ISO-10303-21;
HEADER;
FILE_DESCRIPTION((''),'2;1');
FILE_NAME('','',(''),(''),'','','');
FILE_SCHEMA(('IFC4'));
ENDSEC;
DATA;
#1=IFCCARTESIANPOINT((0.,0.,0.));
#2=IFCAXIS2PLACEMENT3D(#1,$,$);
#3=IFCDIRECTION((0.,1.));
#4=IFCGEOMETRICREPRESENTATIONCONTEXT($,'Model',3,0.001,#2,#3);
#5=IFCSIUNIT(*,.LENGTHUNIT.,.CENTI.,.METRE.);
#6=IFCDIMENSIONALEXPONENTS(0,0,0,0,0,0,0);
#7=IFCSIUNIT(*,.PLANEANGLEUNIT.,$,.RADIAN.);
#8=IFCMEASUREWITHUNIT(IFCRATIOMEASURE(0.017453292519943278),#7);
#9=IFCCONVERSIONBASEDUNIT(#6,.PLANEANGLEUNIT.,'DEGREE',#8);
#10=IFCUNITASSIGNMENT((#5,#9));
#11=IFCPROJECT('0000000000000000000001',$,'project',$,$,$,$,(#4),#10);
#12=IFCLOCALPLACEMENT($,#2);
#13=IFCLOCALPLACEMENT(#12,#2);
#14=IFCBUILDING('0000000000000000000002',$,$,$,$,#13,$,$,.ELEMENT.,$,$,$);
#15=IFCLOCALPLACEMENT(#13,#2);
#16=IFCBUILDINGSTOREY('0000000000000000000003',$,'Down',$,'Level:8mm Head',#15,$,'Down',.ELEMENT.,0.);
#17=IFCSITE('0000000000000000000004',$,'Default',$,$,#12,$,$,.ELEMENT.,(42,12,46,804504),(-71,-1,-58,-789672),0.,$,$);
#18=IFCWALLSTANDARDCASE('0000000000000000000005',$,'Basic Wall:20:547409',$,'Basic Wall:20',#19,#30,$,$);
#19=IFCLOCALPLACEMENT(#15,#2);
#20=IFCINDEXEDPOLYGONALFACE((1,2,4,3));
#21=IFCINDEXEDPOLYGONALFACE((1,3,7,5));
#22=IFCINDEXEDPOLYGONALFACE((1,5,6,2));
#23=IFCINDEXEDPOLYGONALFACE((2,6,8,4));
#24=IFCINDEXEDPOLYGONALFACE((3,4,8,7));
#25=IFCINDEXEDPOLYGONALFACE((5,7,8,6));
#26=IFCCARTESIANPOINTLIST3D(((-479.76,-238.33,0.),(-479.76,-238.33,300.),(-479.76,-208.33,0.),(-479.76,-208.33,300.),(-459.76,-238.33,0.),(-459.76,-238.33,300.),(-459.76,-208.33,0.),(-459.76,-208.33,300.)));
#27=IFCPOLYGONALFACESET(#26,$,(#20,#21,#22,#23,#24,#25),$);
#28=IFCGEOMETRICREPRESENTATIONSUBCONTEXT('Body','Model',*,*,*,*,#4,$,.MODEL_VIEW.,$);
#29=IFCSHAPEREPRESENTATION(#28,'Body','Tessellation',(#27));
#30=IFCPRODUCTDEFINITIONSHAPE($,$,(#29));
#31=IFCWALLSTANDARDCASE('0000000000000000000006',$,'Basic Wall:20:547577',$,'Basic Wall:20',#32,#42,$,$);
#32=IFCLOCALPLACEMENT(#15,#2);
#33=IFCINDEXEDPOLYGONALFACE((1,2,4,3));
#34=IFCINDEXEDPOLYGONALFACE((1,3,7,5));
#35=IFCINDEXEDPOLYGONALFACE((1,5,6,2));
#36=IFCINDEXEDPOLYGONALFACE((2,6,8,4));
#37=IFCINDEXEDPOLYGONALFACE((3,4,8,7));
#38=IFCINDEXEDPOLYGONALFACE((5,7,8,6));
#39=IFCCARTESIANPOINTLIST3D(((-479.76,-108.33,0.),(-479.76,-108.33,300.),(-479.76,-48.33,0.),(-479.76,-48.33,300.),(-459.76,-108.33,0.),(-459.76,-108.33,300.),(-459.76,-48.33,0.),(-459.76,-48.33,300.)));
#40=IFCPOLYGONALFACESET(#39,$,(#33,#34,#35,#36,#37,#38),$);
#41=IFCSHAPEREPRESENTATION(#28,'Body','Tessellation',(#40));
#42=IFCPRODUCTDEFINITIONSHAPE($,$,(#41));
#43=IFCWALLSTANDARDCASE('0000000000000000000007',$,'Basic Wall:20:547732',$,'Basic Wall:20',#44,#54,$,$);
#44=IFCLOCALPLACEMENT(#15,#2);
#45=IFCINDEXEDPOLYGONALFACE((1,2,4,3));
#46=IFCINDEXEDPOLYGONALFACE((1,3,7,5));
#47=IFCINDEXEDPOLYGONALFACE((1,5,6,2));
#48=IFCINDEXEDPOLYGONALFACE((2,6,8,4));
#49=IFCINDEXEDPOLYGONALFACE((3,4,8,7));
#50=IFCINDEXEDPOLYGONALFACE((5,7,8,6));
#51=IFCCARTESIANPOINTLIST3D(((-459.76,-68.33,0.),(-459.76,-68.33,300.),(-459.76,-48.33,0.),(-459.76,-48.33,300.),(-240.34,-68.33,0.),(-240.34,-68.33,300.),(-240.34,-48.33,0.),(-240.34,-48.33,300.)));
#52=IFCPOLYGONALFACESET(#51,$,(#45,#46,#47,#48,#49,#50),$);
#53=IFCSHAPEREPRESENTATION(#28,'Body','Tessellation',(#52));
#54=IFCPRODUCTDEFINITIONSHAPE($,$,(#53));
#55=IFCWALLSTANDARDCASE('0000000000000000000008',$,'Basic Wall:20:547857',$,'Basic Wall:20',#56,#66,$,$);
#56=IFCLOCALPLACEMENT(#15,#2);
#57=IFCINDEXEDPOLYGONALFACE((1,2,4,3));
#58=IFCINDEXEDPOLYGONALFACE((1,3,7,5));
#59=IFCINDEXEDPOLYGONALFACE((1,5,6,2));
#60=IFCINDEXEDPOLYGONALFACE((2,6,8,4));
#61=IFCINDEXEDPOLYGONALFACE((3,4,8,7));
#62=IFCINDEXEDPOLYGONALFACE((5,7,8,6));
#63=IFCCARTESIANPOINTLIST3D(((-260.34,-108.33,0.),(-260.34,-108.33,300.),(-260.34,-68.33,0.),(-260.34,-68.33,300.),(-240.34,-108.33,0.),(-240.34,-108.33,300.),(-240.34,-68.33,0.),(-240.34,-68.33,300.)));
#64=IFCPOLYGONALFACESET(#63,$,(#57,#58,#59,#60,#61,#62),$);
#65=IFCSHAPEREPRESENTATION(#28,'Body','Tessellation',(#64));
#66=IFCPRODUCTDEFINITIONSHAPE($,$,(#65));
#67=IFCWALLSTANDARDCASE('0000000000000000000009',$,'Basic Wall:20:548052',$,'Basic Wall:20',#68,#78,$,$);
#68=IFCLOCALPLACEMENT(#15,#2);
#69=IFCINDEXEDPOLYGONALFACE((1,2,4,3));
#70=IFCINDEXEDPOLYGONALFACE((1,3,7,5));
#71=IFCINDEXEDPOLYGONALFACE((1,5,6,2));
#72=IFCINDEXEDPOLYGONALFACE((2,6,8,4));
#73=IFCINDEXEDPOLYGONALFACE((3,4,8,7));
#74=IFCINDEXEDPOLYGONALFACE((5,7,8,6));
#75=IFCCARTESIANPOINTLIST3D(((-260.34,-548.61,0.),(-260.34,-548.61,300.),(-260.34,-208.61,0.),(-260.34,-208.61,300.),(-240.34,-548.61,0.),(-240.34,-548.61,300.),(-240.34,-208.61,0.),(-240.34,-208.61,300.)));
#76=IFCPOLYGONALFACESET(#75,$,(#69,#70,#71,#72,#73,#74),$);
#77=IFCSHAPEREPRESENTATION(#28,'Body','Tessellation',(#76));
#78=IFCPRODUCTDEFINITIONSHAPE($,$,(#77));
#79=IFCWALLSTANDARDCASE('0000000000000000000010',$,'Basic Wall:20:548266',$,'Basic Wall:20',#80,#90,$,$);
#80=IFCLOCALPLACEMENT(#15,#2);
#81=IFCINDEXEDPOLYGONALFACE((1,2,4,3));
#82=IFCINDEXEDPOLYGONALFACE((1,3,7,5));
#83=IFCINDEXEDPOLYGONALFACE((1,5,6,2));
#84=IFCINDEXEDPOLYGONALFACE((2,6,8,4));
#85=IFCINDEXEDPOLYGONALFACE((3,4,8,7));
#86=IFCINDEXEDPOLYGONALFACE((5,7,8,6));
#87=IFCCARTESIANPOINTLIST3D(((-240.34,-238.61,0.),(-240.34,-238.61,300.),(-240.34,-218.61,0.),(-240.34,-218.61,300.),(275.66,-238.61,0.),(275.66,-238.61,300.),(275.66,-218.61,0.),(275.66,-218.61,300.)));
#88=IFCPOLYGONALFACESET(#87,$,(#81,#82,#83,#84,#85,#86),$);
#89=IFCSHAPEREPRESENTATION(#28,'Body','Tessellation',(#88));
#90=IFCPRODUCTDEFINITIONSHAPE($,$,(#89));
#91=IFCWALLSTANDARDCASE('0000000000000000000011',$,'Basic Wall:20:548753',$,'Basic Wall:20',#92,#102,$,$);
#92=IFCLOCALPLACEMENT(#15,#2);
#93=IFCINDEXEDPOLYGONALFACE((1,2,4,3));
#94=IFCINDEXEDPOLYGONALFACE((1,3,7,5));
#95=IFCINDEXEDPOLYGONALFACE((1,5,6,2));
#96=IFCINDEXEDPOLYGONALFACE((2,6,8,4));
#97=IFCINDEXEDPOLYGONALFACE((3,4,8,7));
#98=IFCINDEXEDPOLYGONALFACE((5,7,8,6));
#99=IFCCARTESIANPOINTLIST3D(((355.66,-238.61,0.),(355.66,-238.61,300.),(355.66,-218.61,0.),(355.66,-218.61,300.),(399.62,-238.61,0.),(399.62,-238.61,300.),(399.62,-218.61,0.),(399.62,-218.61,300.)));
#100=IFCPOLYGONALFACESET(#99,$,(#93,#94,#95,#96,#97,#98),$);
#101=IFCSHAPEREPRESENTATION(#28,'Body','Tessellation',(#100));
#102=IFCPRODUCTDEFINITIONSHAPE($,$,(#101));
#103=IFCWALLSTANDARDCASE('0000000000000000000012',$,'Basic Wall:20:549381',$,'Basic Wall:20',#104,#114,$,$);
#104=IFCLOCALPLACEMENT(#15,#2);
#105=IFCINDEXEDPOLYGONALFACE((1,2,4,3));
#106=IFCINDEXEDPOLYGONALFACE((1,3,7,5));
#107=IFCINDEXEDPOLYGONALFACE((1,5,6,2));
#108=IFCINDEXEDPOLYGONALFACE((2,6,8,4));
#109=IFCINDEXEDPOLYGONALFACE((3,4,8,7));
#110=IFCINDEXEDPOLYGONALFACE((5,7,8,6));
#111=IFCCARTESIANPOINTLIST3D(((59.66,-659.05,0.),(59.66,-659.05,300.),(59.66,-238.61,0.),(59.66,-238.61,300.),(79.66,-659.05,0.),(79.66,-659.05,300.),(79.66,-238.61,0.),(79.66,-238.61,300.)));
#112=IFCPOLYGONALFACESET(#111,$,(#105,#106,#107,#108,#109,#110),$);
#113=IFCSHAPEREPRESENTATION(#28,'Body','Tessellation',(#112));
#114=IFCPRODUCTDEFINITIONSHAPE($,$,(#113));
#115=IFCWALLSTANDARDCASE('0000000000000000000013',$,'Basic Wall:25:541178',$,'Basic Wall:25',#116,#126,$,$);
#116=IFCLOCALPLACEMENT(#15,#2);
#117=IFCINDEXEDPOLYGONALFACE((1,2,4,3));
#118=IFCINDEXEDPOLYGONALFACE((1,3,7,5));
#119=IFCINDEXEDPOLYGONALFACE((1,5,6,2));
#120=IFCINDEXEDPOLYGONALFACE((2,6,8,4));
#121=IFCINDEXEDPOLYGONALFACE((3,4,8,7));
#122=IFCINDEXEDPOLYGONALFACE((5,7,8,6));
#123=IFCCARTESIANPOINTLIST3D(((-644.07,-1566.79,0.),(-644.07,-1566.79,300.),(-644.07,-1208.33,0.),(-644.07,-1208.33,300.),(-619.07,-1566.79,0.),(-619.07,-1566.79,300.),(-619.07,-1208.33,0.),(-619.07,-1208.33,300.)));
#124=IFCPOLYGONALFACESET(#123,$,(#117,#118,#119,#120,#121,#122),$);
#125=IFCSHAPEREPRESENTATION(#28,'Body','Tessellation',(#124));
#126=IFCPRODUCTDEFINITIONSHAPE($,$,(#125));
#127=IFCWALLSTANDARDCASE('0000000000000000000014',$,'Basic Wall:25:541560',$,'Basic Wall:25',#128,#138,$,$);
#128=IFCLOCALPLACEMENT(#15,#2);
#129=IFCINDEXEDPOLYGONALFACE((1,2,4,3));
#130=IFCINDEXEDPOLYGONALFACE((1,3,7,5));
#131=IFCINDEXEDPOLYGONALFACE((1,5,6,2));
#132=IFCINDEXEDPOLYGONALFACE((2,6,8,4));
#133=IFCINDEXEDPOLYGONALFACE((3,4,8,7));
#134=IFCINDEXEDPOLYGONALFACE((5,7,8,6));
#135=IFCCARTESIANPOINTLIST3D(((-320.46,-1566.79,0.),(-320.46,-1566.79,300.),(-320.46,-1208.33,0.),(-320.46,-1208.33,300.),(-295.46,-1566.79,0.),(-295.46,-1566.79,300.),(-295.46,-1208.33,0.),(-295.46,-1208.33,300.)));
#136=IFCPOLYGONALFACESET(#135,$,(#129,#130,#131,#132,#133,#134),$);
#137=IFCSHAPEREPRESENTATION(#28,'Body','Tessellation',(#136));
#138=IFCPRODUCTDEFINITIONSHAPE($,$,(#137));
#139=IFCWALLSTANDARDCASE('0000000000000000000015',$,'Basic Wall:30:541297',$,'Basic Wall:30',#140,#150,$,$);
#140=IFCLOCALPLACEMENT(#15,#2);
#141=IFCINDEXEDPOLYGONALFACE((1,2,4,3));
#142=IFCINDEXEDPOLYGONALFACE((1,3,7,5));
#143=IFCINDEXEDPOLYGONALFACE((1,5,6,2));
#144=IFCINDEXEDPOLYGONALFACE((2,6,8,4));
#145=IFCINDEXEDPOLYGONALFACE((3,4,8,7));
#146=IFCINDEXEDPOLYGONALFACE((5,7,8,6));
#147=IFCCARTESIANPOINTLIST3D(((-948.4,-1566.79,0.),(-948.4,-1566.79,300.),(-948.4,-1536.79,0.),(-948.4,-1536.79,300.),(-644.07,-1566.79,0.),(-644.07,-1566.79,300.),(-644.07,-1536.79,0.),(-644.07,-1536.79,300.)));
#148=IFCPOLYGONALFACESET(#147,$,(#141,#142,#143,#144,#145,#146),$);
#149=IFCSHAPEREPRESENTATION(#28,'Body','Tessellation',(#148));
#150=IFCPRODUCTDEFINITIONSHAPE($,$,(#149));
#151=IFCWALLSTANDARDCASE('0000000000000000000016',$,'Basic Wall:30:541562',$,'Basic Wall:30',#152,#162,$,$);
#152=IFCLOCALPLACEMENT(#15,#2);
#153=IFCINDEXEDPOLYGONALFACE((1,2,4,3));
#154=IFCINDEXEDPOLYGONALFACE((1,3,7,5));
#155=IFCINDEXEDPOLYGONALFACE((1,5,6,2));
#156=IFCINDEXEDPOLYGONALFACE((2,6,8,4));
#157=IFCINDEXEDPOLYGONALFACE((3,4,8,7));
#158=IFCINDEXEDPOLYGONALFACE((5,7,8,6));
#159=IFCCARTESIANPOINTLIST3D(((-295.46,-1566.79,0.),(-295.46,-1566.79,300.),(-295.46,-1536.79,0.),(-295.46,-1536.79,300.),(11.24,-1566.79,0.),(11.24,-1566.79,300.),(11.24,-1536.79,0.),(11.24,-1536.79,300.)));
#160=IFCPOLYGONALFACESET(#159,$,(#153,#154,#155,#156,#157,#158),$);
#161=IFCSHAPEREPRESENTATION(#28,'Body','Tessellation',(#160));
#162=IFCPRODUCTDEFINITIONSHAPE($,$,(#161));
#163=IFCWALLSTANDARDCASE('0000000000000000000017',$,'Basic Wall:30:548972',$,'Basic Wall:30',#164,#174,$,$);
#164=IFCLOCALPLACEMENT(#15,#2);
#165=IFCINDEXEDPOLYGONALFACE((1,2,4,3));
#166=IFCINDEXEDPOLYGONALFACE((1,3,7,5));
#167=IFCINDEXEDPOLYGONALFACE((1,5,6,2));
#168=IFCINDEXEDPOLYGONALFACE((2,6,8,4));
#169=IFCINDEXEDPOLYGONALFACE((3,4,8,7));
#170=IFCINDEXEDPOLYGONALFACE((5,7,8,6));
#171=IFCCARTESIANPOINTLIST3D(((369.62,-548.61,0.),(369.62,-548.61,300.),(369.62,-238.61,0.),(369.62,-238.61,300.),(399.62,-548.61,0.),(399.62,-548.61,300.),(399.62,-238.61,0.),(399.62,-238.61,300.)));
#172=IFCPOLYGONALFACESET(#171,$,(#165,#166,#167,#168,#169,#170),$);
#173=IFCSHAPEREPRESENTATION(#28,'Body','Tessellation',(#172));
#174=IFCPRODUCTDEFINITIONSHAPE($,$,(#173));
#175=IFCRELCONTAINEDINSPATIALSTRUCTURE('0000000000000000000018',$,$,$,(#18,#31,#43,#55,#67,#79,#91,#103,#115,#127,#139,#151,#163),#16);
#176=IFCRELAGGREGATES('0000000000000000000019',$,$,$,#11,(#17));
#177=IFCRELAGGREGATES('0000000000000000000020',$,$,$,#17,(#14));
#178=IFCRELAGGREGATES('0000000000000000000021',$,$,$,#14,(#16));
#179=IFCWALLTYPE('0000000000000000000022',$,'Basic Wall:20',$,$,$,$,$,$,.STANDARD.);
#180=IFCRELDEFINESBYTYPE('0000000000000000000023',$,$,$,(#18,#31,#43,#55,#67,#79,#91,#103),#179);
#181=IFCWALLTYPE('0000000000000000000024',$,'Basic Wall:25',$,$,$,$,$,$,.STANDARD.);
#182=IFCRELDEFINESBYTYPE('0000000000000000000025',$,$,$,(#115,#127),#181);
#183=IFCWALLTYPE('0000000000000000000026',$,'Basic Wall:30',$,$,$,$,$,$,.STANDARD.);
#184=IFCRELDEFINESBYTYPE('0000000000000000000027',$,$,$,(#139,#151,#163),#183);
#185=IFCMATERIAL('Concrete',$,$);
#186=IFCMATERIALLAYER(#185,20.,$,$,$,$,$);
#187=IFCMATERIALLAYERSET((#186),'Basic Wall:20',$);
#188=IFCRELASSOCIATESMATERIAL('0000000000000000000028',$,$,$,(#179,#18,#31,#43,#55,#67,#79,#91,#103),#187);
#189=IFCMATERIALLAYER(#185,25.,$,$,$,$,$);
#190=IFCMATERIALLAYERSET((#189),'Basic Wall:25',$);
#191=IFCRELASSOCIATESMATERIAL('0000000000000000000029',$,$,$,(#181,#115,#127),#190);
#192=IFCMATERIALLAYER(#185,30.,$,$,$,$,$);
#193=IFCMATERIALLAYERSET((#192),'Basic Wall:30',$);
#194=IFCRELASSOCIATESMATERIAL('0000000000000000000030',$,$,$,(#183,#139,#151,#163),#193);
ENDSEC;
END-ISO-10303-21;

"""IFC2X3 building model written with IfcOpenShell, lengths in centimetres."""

from ifc_helpers import new_model, entity, si_unit, converted_unit, direction, frame, frame_2d, origin, place, context, subcontext, project, spatial, rectangle, extrude, material, layer, layer_set, layer_usage, type_object, element, save


model = new_model("IFC2X3")

# Units and contexts
model_context = context("Model", 3, precision=0.001, world=origin(), true_north=direction((0.0, 1.0)))
body_context = subcontext(model_context, "Body", "Model", "MODEL_VIEW")
ifc_project = project(units=[si_unit("LENGTHUNIT", "METRE", prefix="CENTI"), converted_unit("PLANEANGLEUNIT", "DEGREE", entity("IfcRatioMeasure", 0.017453292519943278), si_unit("PLANEANGLEUNIT", "RADIAN"), dimensions=[0, 0, 0, 0, 0, 0, 0])], contexts=[model_context])

# Site, building, storey
site_placement = place(None, origin())
site = spatial("IfcSite", under=ifc_project, at=site_placement, Name="Default", CompositionType="ELEMENT", RefLatitude=(42, 12, 46, 804504), RefLongitude=(-71, -1, -58, -789672), RefElevation=0.0)
building_placement = place(site_placement, origin())
building = spatial("IfcBuilding", under=site, at=building_placement, CompositionType="ELEMENT")
storey_placement = place(building_placement, origin())
storey = spatial("IfcBuildingStorey", under=building, at=storey_placement, Name="Down", ObjectType="Level:8mm Head", LongName="Down", CompositionType="ELEMENT", Elevation=0.0)

# Shared definitions
ifc_material = material(Name="Concrete")

# Walls
ifc_layer_1 = layer(ifc_material, 20.0)
ifc_layer_set_1 = layer_set([ifc_layer_1], Name="Basic Wall:20")
wall_type_1 = type_object("IfcWallType", Name="Basic Wall:20", PredefinedType="STANDARD", material=ifc_layer_set_1)
ifc_layer_usage_1 = layer_usage(ifc_layer_set_1, "AXIS2", "POSITIVE", -10.0)
wall_1_placement = place(storey_placement, frame((-469.76, -238.33, 0.0), z_axis=(0.0, 0.0, 1.0), x_axis=(0.0, 1.0, 0.0)))
element("IfcWallStandardCase", 1, at=wall_1_placement, inside=storey, type_object=wall_type_1, material=ifc_layer_usage_1, Name="Basic Wall:20:547409", ObjectType="Basic Wall:20", context=body_context, shape_type="SweptSolid", body=[
    extrude(rectangle(XDim=30.0, YDim=20.0, at=frame_2d((15.0, 0.0), x_axis=(-1.0, 0.0))), origin(), (0.0, 0.0, 1.0), 300.0),
])
ifc_layer_usage_2 = layer_usage(ifc_layer_set_1, "AXIS2", "POSITIVE", -10.0)
wall_2_placement = place(storey_placement, frame((-469.76, -108.33, 0.0), z_axis=(0.0, 0.0, 1.0), x_axis=(0.0, 1.0, 0.0)))
element("IfcWallStandardCase", 2, at=wall_2_placement, inside=storey, type_object=wall_type_1, material=ifc_layer_usage_2, Name="Basic Wall:20:547577", ObjectType="Basic Wall:20", context=body_context, shape_type="SweptSolid", body=[
    extrude(rectangle(XDim=60.0, YDim=20.0, at=frame_2d((30.0, 0.0), x_axis=(-1.0, 0.0))), origin(), (0.0, 0.0, 1.0), 300.0),
])
ifc_layer_usage_3 = layer_usage(ifc_layer_set_1, "AXIS2", "NEGATIVE", 10.0)
wall_3_placement = place(storey_placement, frame((-459.76, -58.33, 0.0)))
element("IfcWallStandardCase", 3, at=wall_3_placement, inside=storey, type_object=wall_type_1, material=ifc_layer_usage_3, Name="Basic Wall:20:547732", ObjectType="Basic Wall:20", context=body_context, shape_type="SweptSolid", body=[
    extrude(rectangle(XDim=219.43, YDim=20.0, at=frame_2d((109.71, 0.0), x_axis=(-1.0, 0.0))), origin(), (0.0, 0.0, 1.0), 300.0),
])
ifc_layer_usage_4 = layer_usage(ifc_layer_set_1, "AXIS2", "NEGATIVE", 10.0)
wall_4_placement = place(storey_placement, frame((-250.34, -68.33, 0.0), z_axis=(0.0, 0.0, 1.0), x_axis=(0.0, -1.0, 0.0)))
element("IfcWallStandardCase", 4, at=wall_4_placement, inside=storey, type_object=wall_type_1, material=ifc_layer_usage_4, Name="Basic Wall:20:547857", ObjectType="Basic Wall:20", context=body_context, shape_type="SweptSolid", body=[
    extrude(rectangle(XDim=40.0, YDim=20.0, at=frame_2d((20.0, 0.0), x_axis=(-1.0, 0.0))), origin(), (0.0, 0.0, 1.0), 300.0),
])
ifc_layer_usage_5 = layer_usage(ifc_layer_set_1, "AXIS2", "NEGATIVE", 10.0)
wall_5_placement = place(storey_placement, frame((-250.34, -208.61, 0.0), z_axis=(0.0, 0.0, 1.0), x_axis=(0.0, -1.0, 0.0)))
element("IfcWallStandardCase", 5, at=wall_5_placement, inside=storey, type_object=wall_type_1, material=ifc_layer_usage_5, Name="Basic Wall:20:548052", ObjectType="Basic Wall:20", context=body_context, shape_type="SweptSolid", body=[
    extrude(rectangle(XDim=340.0, YDim=20.0, at=frame_2d((170.0, 0.0), x_axis=(-1.0, 0.0))), origin(), (0.0, 0.0, 1.0), 300.0),
])
ifc_layer_usage_6 = layer_usage(ifc_layer_set_1, "AXIS2", "POSITIVE", -10.0)
wall_6_placement = place(storey_placement, frame((-240.34, -228.61, 0.0)))
element("IfcWallStandardCase", 6, at=wall_6_placement, inside=storey, type_object=wall_type_1, material=ifc_layer_usage_6, Name="Basic Wall:20:548266", ObjectType="Basic Wall:20", context=body_context, shape_type="SweptSolid", body=[
    extrude(rectangle(XDim=516.0, YDim=20.0, at=frame_2d((258.0, 0.0), x_axis=(-1.0, 0.0))), origin(), (0.0, 0.0, 1.0), 300.0),
])
ifc_layer_usage_7 = layer_usage(ifc_layer_set_1, "AXIS2", "POSITIVE", -10.0)
wall_7_placement = place(storey_placement, frame((355.66, -228.61, 0.0)))
element("IfcWallStandardCase", 7, at=wall_7_placement, inside=storey, type_object=wall_type_1, material=ifc_layer_usage_7, Name="Basic Wall:20:548753", ObjectType="Basic Wall:20", context=body_context, shape_type="SweptSolid", body=[
    extrude(rectangle(XDim=43.95, YDim=20.0, at=frame_2d((21.98, 0.0), x_axis=(-1.0, 0.0))), origin(), (0.0, 0.0, 1.0), 300.0),
])
ifc_layer_usage_8 = layer_usage(ifc_layer_set_1, "AXIS2", "NEGATIVE", 10.0)
wall_8_placement = place(storey_placement, frame((69.66, -238.61, 0.0), z_axis=(0.0, 0.0, 1.0), x_axis=(0.0, -1.0, 0.0)))
element("IfcWallStandardCase", 8, at=wall_8_placement, inside=storey, type_object=wall_type_1, material=ifc_layer_usage_8, Name="Basic Wall:20:549381", ObjectType="Basic Wall:20", context=body_context, shape_type="SweptSolid", body=[
    extrude(rectangle(XDim=420.44, YDim=20.0, at=frame_2d((210.22, 0.0), x_axis=(-1.0, 0.0))), origin(), (0.0, 0.0, 1.0), 300.0),
])
ifc_layer_2 = layer(ifc_material, 25.0)
ifc_layer_set_2 = layer_set([ifc_layer_2], Name="Basic Wall:25")
ifc_layer_usage_9 = layer_usage(ifc_layer_set_2, "AXIS2", "NEGATIVE", 12.5)
wall_type_2 = type_object("IfcWallType", Name="Basic Wall:25", PredefinedType="STANDARD", material=ifc_layer_set_2)
wall_9_placement = place(storey_placement, frame((-631.57, -1208.33, 0.0), z_axis=(0.0, 0.0, 1.0), x_axis=(0.0, -1.0, 0.0)))
element("IfcWallStandardCase", 9, at=wall_9_placement, inside=storey, type_object=wall_type_2, material=ifc_layer_usage_9, Name="Basic Wall:25:541178", ObjectType="Basic Wall:25", context=body_context, shape_type="SweptSolid", body=[
    extrude(rectangle(XDim=358.46, YDim=25.0, at=frame_2d((179.23, 0.0), x_axis=(-1.0, 0.0))), origin(), (0.0, 0.0, 1.0), 300.0),
])
ifc_layer_usage_10 = layer_usage(ifc_layer_set_2, "AXIS2", "POSITIVE", -12.5)
wall_10_placement = place(storey_placement, frame((-307.96, -1208.33, 0.0), z_axis=(0.0, 0.0, 1.0), x_axis=(0.0, -1.0, 0.0)))
element("IfcWallStandardCase", 10, at=wall_10_placement, inside=storey, type_object=wall_type_2, material=ifc_layer_usage_10, Name="Basic Wall:25:541560", ObjectType="Basic Wall:25", context=body_context, shape_type="SweptSolid", body=[
    extrude(rectangle(XDim=358.46, YDim=25.0, at=frame_2d((179.23, 0.0), x_axis=(-1.0, 0.0))), origin(), (0.0, 0.0, 1.0), 300.0),
])
ifc_layer_3 = layer(ifc_material, 30.0)
ifc_layer_set_3 = layer_set([ifc_layer_3], Name="Basic Wall:30")
ifc_layer_usage_11 = layer_usage(ifc_layer_set_3, "AXIS2", "NEGATIVE", 15.0)
wall_type_3 = type_object("IfcWallType", Name="Basic Wall:30", PredefinedType="STANDARD", material=ifc_layer_set_3)
wall_11_placement = place(storey_placement, frame((-644.07, -1551.79, 0.0), z_axis=(0.0, 0.0, 1.0), x_axis=(-1.0, 0.0, 0.0)))
element("IfcWallStandardCase", 11, at=wall_11_placement, inside=storey, type_object=wall_type_3, material=ifc_layer_usage_11, Name="Basic Wall:30:541297", ObjectType="Basic Wall:30", context=body_context, shape_type="SweptSolid", body=[
    extrude(rectangle(XDim=304.33, YDim=30.0, at=frame_2d((152.17, 0.0), x_axis=(-1.0, 0.0))), origin(), (0.0, 0.0, 1.0), 300.0),
])
ifc_layer_usage_12 = layer_usage(ifc_layer_set_3, "AXIS2", "POSITIVE", -15.0)
wall_12_placement = place(storey_placement, frame((-295.46, -1551.79, 0.0)))
element("IfcWallStandardCase", 12, at=wall_12_placement, inside=storey, type_object=wall_type_3, material=ifc_layer_usage_12, Name="Basic Wall:30:541562", ObjectType="Basic Wall:30", context=body_context, shape_type="SweptSolid", body=[
    extrude(rectangle(XDim=306.7, YDim=30.0, at=frame_2d((153.35, 0.0), x_axis=(-1.0, 0.0))), origin(), (0.0, 0.0, 1.0), 300.0),
])
ifc_layer_usage_13 = layer_usage(ifc_layer_set_3, "AXIS2", "NEGATIVE", 15.0)
wall_13_placement = place(storey_placement, frame((384.62, -238.61, 0.0), z_axis=(0.0, 0.0, 1.0), x_axis=(0.0, -1.0, 0.0)))
element("IfcWallStandardCase", 13, at=wall_13_placement, inside=storey, type_object=wall_type_3, material=ifc_layer_usage_13, Name="Basic Wall:30:548972", ObjectType="Basic Wall:30", context=body_context, shape_type="SweptSolid", body=[
    extrude(rectangle(XDim=310.0, YDim=30.0, at=frame_2d((155.0, 0.0), x_axis=(-1.0, 0.0))), origin(), (0.0, 0.0, 1.0), 300.0),
])

save(model, "model.ifc")
